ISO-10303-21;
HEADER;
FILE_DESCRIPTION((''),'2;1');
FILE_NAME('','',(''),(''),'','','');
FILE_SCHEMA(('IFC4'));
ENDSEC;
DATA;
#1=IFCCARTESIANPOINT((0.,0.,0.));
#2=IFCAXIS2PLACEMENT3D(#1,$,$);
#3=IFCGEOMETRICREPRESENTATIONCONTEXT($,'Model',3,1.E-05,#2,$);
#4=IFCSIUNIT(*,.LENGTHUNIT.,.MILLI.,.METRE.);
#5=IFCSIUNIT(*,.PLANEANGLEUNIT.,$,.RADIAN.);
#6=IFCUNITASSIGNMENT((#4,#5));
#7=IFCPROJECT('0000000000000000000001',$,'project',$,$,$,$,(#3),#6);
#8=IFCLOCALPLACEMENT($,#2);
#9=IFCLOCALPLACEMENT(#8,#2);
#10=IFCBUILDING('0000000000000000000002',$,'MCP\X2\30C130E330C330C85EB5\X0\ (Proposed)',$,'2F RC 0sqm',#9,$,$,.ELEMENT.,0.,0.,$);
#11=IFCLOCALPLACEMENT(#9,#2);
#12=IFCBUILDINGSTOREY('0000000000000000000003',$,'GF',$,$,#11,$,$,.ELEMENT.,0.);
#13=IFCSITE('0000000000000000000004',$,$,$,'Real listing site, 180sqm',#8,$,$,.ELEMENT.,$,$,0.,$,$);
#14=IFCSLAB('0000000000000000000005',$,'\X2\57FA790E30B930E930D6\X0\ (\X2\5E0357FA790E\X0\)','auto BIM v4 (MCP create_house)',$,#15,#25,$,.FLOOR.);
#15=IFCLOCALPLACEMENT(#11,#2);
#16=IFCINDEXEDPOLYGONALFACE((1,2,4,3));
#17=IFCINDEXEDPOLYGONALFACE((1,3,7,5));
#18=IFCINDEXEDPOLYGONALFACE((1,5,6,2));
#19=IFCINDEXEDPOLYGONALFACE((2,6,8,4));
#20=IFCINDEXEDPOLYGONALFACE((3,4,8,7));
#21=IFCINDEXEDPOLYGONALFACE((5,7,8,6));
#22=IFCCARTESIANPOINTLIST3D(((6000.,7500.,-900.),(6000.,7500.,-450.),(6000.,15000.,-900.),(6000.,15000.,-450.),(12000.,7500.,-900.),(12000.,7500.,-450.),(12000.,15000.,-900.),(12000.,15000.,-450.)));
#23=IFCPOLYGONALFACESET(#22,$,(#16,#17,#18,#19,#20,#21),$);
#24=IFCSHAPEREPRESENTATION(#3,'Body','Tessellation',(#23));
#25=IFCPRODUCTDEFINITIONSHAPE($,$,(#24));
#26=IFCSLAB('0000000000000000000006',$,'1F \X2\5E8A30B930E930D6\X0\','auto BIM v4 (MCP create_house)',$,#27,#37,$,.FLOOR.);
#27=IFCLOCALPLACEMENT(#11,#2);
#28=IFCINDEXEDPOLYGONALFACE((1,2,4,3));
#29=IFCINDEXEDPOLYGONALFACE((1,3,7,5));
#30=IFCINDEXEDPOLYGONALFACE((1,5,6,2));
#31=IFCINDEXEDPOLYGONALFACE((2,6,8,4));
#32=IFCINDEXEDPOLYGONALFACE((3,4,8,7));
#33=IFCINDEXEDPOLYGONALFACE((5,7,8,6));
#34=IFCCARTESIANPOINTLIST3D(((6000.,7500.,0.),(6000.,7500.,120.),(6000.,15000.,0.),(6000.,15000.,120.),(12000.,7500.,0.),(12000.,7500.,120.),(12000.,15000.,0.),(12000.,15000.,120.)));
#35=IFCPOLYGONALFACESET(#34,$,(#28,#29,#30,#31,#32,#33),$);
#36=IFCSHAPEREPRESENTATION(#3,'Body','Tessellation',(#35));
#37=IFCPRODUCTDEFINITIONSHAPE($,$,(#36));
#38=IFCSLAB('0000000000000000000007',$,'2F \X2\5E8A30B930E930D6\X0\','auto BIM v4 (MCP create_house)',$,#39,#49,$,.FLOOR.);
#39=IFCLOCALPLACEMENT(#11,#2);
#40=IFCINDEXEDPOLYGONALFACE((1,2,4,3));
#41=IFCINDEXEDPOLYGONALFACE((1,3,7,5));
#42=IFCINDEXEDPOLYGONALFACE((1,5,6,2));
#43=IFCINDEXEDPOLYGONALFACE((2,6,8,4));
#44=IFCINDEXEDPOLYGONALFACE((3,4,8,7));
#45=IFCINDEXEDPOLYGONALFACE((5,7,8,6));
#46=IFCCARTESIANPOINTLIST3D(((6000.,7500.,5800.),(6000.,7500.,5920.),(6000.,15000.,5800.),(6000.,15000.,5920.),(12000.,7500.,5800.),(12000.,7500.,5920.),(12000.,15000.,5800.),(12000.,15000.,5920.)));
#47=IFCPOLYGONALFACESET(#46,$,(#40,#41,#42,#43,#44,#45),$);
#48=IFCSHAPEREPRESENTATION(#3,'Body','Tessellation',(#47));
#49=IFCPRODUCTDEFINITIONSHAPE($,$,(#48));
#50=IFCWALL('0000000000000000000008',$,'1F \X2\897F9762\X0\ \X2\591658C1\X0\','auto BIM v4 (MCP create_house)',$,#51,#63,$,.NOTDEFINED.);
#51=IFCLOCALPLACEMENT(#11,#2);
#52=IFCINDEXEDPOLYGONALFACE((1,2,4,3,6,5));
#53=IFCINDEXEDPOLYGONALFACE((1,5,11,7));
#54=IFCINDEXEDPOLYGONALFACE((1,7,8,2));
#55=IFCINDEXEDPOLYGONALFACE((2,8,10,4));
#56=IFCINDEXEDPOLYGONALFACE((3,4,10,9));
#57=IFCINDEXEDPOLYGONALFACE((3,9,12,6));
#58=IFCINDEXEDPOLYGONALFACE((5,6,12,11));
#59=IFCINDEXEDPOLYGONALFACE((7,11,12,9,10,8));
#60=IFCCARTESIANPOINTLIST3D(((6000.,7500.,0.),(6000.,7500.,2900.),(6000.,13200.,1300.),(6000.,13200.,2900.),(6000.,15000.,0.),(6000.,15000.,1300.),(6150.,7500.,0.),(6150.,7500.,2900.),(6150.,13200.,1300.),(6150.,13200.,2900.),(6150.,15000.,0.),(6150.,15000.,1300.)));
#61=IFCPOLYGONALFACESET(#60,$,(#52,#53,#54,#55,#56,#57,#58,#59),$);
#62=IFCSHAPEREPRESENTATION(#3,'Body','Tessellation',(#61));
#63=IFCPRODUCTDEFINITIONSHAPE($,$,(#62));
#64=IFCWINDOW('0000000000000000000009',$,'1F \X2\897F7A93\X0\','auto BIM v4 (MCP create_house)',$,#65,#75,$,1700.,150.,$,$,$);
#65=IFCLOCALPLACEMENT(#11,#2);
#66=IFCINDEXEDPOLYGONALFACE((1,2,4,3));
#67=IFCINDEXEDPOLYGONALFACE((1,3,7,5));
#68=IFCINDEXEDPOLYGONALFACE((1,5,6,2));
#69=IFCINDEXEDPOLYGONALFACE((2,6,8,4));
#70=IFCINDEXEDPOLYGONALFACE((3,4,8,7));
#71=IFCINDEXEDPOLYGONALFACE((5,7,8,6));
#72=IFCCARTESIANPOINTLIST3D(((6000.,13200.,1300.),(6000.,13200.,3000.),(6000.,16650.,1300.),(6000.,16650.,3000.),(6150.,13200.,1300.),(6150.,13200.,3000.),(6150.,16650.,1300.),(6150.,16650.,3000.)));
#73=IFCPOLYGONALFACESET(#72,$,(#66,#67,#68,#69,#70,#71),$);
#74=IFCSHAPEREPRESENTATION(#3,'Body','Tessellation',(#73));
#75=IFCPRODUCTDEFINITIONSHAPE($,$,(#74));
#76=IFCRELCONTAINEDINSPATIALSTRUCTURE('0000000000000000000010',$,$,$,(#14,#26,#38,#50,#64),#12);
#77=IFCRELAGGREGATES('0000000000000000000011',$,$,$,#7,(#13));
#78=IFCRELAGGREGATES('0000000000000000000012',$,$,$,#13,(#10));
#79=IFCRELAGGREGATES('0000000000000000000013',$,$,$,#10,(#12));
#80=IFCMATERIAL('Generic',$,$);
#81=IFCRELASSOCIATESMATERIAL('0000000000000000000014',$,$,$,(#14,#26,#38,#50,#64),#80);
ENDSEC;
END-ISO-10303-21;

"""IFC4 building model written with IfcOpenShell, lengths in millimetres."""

from ifc_helpers import new_model, si_unit, frame, frame_2d, origin, place, context, project, spatial, rectangle, extrude, material, element, fill, save


model = new_model("IFC4")

# Units and contexts
model_context = context("Model", 3, precision=1e-05, world=origin())
ifc_project = project(units=[si_unit("LENGTHUNIT", "METRE", prefix="MILLI"), si_unit("PLANEANGLEUNIT", "RADIAN")], contexts=[model_context])

# Site, building, storey
site_placement = place(None, origin())
site = spatial("IfcSite", under=ifc_project, at=site_placement, ObjectType="Real listing site, 180sqm", CompositionType="ELEMENT", RefElevation=0.0)
building_placement = place(site_placement, origin())
building = spatial("IfcBuilding", under=site, at=building_placement, Name="MCPチャット庵 (Proposed)", ObjectType="2F RC 0sqm", CompositionType="ELEMENT", ElevationOfRefHeight=0.0, ElevationOfTerrain=0.0)
storey_placement = place(building_placement, origin())
storey = spatial("IfcBuildingStorey", under=building, at=storey_placement, Name="GF", CompositionType="ELEMENT", Elevation=0.0)

# Slabs
ifc_material = material(Name="Generic")
slab_1_placement = place(storey_placement, frame((3000.0, 3750.0, -450.0)))
element("IfcSlab", 1, at=slab_1_placement, inside=storey, material=ifc_material, Name="基礎スラブ (布基礎)", Description="auto BIM v4 (MCP create_house)", PredefinedType="FLOOR", context=model_context, shape_type="SweptSolid", body=[
    extrude(rectangle(XDim=6000.0, YDim=7500.0, at=frame_2d((3000.0, 3750.0))), frame((3000.0, 3750.0, -450.0)), (0.0, 0.0, 1.0), 450.0),
])
slab_2_placement = place(storey_placement, frame((3000.0, 3750.0, 0.0)))
element("IfcSlab", 2, at=slab_2_placement, inside=storey, material=ifc_material, Name="1F 床スラブ", Description="auto BIM v4 (MCP create_house)", PredefinedType="FLOOR", context=model_context, shape_type="SweptSolid", body=[
    extrude(rectangle(XDim=6000.0, YDim=7500.0, at=frame_2d((3000.0, 3750.0))), frame((3000.0, 3750.0, 0.0)), (0.0, 0.0, 1.0), 120.0),
])
slab_3_placement = place(storey_placement, frame((3000.0, 3750.0, 2900.0)))
element("IfcSlab", 3, at=slab_3_placement, inside=storey, material=ifc_material, Name="2F 床スラブ", Description="auto BIM v4 (MCP create_house)", PredefinedType="FLOOR", context=model_context, shape_type="SweptSolid", body=[
    extrude(rectangle(XDim=6000.0, YDim=7500.0, at=frame_2d((3000.0, 3750.0))), frame((3000.0, 3750.0, 2900.0)), (0.0, 0.0, 1.0), 120.0),
])

# Wall, opening, window
wall_1_placement = place(storey_placement, frame((3000.0, 3750.0, 0.0)))
wall_1 = element("IfcWall", 4, at=wall_1_placement, inside=storey, material=ifc_material, Name="1F 西面 外壁", Description="auto BIM v4 (MCP create_house)", PredefinedType="NOTDEFINED", context=model_context, shape_type="SweptSolid", body=[
    extrude(rectangle(XDim=150.0, YDim=7500.0, at=frame_2d((75.0, 3750.0))), frame((3000.0, 3750.0, 0.0)), (0.0, 0.0, 1.0), 2900.0),
])
opening_1_placement = place(storey_placement, frame((3000.0, 6600.0, 650.0)))
opening_1 = element("IfcOpeningElement", 5, at=opening_1_placement, cuts=wall_1, PredefinedType="NOTDEFINED", context=model_context, shape_type="SweptSolid", body=[
    extrude(rectangle(XDim=150.0, YDim=3450.0, at=frame_2d((75.0, 1725.0))), frame((3000.0, 6600.0, 650.0)), (0.0, 0.0, 1.0), 1700.0),
])
window_1_placement = place(storey_placement, frame((3000.0, 6600.0, 650.0)))
window_1 = element("IfcWindow", 6, at=window_1_placement, inside=storey, material=ifc_material, Name="1F 西窓", Description="auto BIM v4 (MCP create_house)", OverallHeight=1700.0, OverallWidth=150.0, context=model_context, shape_type="SweptSolid", body=[
    extrude(rectangle(XDim=150.0, YDim=3450.0, at=frame_2d((75.0, 1725.0))), frame((3000.0, 6600.0, 650.0)), (0.0, 0.0, 1.0), 1700.0),
])
fill(opening_1, window_1)

save(model, "model.ifc")
